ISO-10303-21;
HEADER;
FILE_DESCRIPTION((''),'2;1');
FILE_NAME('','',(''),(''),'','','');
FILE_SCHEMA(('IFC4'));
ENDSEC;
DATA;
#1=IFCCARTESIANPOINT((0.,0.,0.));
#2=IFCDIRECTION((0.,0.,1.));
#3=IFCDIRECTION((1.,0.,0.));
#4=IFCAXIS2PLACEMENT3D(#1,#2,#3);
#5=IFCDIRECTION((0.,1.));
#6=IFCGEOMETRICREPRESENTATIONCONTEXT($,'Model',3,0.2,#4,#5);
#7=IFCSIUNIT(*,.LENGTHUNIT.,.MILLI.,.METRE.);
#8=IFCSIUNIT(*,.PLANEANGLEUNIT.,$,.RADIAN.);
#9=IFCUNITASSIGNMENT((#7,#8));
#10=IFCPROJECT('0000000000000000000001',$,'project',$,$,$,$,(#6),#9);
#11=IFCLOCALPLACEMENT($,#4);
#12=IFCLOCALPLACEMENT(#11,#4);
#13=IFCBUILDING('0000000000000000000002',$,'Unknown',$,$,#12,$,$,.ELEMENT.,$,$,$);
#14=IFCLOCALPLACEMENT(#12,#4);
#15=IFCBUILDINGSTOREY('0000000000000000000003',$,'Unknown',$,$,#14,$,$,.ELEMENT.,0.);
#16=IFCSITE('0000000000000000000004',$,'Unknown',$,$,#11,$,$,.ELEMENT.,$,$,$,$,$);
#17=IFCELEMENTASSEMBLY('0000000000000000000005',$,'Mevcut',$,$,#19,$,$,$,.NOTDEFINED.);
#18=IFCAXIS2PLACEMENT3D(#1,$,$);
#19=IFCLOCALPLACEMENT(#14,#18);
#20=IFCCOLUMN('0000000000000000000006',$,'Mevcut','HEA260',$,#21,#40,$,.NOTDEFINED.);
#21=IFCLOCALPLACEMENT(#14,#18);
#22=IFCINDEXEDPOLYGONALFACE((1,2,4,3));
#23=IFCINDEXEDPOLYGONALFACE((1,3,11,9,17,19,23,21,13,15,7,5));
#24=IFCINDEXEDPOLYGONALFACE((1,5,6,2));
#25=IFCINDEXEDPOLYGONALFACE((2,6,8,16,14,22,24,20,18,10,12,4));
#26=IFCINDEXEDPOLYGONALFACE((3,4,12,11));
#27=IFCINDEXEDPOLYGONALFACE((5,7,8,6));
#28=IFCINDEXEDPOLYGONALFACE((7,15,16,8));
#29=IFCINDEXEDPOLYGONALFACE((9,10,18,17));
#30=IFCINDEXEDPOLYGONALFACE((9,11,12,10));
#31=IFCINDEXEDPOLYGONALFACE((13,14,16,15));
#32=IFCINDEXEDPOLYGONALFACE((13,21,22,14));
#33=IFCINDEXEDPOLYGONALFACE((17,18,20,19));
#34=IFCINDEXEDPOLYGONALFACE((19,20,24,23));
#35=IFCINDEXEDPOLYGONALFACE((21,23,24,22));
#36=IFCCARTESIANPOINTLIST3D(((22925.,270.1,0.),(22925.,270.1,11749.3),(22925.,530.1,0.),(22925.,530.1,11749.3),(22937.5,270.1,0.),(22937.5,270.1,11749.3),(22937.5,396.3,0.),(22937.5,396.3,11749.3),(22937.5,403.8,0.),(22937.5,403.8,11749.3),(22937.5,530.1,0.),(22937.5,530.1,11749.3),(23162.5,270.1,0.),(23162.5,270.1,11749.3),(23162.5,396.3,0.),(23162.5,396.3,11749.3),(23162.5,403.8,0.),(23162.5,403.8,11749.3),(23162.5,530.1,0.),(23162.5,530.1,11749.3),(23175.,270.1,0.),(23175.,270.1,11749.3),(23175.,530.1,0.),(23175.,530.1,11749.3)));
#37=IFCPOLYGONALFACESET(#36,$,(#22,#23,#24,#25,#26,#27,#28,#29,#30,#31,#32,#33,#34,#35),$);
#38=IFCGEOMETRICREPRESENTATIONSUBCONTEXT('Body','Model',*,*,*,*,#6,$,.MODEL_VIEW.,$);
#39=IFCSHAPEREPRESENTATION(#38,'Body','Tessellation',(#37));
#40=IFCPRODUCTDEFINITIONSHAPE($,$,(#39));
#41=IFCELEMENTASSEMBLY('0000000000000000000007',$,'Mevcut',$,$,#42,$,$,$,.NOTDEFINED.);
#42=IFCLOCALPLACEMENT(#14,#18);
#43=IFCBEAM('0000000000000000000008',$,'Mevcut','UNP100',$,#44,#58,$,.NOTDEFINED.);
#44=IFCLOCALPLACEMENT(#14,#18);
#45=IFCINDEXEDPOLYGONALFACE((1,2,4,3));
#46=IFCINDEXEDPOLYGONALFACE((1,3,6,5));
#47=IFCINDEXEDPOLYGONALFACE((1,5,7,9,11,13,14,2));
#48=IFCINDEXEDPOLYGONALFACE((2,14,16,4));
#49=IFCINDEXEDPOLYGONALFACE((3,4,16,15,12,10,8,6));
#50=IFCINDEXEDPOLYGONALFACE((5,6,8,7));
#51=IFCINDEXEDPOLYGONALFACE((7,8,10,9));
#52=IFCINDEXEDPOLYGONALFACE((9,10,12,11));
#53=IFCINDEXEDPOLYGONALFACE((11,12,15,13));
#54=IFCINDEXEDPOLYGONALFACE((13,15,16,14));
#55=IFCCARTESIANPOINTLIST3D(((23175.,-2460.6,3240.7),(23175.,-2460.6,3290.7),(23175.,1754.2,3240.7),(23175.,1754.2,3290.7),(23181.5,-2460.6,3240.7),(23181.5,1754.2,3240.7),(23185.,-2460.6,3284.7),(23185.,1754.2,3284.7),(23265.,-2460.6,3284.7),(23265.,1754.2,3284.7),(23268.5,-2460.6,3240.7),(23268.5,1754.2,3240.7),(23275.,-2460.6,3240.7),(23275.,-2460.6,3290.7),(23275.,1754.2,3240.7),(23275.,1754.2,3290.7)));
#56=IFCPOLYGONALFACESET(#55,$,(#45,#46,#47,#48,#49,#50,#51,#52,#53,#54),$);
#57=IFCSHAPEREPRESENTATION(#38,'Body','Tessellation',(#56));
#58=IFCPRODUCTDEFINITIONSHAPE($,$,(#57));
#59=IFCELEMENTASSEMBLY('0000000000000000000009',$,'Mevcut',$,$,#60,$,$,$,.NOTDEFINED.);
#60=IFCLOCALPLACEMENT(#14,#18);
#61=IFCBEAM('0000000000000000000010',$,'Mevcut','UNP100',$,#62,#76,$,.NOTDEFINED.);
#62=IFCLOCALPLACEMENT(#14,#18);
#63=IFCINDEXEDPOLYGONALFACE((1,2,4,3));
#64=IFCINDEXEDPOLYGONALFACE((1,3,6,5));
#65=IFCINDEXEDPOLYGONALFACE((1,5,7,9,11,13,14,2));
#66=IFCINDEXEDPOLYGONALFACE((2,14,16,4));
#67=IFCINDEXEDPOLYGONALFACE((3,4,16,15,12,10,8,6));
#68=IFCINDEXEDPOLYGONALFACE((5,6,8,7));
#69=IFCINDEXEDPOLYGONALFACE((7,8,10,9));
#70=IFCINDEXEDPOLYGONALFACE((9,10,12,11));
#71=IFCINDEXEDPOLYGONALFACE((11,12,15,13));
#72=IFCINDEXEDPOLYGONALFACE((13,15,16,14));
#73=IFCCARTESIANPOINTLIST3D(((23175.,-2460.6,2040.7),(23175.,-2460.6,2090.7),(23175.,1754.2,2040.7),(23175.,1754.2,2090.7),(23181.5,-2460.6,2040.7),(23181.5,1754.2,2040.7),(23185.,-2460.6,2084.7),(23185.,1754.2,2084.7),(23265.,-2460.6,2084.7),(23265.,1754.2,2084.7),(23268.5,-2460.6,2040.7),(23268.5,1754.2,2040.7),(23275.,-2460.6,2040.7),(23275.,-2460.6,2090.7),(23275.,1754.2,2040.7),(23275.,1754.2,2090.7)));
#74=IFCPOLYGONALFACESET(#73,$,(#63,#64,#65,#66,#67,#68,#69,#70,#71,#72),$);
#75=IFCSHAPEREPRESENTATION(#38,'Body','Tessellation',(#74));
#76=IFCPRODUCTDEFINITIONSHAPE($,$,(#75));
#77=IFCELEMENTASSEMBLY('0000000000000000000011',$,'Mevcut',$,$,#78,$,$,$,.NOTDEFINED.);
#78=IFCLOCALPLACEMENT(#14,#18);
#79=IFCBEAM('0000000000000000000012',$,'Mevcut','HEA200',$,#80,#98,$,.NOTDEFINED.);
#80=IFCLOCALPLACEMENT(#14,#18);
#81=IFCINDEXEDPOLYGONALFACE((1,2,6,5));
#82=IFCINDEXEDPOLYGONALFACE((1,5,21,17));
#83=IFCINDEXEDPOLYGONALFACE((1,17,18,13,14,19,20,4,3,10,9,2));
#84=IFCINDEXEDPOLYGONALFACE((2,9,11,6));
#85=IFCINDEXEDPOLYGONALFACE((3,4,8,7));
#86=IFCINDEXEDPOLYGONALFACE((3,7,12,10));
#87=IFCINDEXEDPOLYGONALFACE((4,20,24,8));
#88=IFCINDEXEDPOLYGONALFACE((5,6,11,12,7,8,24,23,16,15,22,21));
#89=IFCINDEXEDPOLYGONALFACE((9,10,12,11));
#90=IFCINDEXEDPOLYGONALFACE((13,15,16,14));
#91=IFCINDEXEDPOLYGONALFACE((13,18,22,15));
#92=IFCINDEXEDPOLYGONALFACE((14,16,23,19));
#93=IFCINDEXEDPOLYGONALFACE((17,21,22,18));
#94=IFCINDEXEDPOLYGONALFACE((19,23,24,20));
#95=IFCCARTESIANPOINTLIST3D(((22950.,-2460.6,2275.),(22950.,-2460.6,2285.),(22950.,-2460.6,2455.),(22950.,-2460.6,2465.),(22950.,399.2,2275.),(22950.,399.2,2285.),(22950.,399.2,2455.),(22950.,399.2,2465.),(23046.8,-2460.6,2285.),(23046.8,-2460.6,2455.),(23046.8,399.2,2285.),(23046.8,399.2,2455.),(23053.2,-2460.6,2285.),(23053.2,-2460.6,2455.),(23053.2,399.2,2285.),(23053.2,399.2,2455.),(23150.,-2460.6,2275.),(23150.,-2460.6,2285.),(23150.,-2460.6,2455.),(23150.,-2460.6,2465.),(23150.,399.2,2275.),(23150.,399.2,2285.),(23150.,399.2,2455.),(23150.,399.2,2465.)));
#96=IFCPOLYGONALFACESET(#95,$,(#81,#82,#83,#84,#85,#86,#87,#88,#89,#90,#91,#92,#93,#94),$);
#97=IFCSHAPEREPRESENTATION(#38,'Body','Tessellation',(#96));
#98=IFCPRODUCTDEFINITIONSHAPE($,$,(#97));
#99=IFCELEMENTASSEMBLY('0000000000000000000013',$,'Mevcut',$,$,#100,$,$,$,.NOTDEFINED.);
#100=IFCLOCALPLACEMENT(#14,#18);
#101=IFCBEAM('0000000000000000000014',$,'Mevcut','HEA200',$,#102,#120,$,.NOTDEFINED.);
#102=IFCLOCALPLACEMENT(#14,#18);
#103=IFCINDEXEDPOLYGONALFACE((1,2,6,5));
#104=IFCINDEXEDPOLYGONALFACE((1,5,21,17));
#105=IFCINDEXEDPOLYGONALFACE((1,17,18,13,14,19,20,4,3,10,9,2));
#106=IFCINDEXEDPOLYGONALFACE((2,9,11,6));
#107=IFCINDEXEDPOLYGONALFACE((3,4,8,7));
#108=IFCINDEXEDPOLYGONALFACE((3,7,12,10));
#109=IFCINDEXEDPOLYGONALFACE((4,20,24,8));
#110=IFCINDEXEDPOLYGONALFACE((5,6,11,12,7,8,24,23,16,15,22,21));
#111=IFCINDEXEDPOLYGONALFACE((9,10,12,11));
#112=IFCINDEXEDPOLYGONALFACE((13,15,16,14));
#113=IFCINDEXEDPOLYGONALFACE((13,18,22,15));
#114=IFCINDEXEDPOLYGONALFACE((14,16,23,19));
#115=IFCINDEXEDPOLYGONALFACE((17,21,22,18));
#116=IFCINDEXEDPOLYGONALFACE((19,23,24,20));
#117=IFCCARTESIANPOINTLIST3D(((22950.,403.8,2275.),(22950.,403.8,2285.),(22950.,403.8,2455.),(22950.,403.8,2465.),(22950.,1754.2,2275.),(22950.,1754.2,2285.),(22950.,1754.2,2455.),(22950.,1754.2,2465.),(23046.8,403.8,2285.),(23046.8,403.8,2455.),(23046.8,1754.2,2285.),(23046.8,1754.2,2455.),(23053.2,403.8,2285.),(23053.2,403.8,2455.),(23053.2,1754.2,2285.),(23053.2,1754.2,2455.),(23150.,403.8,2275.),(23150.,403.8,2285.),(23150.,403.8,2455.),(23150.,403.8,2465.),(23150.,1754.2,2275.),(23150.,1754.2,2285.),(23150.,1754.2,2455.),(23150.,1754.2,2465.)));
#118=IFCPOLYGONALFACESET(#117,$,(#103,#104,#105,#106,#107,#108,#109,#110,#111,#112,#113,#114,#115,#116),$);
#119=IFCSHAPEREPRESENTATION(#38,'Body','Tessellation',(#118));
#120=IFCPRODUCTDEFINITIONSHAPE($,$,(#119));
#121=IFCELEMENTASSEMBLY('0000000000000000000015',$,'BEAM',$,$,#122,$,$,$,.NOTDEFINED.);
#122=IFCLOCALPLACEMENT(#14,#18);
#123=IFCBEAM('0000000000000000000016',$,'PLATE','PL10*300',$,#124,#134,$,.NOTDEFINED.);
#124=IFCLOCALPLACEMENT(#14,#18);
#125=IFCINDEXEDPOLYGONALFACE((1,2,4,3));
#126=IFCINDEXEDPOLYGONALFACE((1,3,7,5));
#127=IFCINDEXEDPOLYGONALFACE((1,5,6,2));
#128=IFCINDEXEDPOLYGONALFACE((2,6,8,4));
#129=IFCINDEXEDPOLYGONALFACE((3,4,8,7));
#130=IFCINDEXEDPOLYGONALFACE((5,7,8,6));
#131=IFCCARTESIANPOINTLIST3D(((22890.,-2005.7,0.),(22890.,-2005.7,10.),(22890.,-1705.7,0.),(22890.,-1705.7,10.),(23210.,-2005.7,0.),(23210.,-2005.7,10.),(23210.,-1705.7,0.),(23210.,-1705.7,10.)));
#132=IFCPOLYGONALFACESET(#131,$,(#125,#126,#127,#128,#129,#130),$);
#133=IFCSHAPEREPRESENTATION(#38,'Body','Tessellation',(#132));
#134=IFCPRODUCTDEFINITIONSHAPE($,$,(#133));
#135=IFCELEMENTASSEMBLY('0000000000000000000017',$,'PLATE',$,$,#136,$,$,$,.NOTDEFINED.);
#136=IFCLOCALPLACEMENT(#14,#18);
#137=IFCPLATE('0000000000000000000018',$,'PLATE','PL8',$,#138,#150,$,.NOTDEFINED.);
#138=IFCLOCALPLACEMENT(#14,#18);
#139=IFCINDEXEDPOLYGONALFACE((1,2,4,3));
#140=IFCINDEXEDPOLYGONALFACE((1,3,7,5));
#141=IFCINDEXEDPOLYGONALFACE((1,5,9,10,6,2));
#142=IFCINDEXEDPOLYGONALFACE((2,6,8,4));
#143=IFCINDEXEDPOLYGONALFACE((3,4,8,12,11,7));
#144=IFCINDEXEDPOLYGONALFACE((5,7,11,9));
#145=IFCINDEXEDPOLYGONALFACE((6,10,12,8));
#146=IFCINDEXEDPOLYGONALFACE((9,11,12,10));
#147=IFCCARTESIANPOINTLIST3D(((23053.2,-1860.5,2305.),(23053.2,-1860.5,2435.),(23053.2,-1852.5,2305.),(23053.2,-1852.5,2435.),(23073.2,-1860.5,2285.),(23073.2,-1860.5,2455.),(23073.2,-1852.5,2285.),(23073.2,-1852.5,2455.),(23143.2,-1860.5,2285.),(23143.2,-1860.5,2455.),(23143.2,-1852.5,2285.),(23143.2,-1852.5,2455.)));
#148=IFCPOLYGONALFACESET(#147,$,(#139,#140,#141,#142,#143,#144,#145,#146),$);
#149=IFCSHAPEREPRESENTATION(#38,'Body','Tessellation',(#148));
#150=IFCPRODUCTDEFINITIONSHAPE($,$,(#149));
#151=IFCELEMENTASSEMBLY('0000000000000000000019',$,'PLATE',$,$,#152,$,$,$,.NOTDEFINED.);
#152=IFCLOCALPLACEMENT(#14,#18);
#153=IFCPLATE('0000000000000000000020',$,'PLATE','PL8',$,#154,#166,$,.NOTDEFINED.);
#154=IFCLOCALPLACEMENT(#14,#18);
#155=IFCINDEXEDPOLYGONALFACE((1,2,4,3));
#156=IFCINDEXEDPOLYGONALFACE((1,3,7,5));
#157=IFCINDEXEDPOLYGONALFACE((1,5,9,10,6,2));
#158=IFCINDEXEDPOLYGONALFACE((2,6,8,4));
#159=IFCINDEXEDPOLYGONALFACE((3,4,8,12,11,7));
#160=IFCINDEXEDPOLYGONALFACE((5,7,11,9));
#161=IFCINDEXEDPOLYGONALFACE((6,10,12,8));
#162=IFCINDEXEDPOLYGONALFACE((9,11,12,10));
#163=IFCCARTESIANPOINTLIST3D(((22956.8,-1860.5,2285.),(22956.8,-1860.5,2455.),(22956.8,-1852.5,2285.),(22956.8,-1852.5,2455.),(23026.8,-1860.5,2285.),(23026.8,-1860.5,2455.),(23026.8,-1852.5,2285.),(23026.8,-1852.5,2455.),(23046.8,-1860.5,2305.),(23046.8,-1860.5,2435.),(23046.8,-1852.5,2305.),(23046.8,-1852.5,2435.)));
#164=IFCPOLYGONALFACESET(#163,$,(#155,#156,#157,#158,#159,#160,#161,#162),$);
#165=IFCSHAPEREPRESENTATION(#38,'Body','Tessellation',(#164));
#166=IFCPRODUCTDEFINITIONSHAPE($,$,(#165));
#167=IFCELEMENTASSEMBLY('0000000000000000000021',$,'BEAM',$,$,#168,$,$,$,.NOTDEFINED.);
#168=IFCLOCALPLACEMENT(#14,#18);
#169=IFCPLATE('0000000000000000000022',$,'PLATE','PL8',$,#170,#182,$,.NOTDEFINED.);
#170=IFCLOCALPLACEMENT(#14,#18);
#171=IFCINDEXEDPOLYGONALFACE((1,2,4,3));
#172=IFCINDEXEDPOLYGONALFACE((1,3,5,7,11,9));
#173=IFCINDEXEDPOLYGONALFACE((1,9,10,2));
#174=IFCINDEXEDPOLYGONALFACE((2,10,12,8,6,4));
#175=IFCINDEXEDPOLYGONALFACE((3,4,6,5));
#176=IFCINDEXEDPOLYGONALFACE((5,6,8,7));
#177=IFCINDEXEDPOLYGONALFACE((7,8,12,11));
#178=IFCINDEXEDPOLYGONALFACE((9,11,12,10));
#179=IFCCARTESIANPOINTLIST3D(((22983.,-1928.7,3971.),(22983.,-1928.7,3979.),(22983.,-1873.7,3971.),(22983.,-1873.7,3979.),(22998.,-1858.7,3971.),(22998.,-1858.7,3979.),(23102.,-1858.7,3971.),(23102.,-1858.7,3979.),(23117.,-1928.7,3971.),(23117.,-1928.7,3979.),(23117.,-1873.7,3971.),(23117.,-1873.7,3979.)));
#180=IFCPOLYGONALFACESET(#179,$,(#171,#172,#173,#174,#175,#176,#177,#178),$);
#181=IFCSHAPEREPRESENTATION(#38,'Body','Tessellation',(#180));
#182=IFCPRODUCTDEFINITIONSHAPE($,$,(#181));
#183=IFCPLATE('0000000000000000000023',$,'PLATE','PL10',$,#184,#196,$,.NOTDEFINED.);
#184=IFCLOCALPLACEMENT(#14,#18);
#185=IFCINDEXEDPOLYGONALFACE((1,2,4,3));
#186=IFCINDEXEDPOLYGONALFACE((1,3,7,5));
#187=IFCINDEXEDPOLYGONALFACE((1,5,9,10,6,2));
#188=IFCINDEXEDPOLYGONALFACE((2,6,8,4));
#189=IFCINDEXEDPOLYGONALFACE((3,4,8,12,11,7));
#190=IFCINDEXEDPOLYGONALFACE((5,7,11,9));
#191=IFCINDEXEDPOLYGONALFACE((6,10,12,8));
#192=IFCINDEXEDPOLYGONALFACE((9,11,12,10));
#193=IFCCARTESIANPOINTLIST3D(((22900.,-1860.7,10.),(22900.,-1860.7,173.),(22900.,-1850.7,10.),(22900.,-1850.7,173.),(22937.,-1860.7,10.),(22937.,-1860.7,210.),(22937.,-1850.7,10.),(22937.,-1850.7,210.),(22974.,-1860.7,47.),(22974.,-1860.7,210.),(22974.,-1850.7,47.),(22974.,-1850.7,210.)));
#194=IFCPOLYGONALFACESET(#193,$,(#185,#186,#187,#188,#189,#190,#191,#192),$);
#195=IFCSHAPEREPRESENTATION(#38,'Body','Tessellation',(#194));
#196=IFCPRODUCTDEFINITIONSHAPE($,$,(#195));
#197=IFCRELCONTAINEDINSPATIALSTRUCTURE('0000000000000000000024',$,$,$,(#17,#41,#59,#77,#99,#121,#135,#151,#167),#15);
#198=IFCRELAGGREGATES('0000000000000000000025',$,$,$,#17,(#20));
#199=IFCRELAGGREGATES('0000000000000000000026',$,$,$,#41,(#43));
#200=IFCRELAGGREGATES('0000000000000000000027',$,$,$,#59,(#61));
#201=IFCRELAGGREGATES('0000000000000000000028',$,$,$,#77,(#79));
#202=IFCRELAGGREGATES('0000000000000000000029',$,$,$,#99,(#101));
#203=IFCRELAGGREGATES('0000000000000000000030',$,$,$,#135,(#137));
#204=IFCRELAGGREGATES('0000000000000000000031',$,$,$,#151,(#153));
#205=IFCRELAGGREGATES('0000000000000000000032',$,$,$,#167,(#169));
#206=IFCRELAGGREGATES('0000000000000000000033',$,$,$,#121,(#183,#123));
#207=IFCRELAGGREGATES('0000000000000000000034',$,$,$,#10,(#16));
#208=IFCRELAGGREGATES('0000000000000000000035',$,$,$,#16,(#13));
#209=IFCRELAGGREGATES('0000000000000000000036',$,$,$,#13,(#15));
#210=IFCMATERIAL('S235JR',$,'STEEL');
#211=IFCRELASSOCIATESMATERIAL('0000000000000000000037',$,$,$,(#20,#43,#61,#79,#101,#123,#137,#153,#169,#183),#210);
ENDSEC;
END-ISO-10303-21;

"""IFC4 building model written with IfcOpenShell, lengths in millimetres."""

from ifc_helpers import new_model, si_unit, direction, frame, origin_with_axes, place, context, subcontext, project, spatial, line, indexed_curve, outline, extrude, material, element, aggregate, save


model = new_model("IFC4")

# Units and contexts
model_context = context("Model", 3, precision=0.2, world=origin_with_axes(), true_north=direction((0.0, 1.0)))
body_context = subcontext(model_context, "Body", "Model", "MODEL_VIEW")
ifc_project = project(units=[si_unit("LENGTHUNIT", "METRE", prefix="MILLI"), si_unit("PLANEANGLEUNIT", "RADIAN")], contexts=[model_context])

# Site, building, storey
site_placement = place(None, origin_with_axes())
site = spatial("IfcSite", under=ifc_project, at=site_placement, Name="Unknown", CompositionType="ELEMENT")
building_placement = place(site_placement, origin_with_axes())
building = spatial("IfcBuilding", under=site, at=building_placement, Name="Unknown", CompositionType="ELEMENT")
storey_placement = place(building_placement, origin_with_axes())
storey = spatial("IfcBuildingStorey", under=building, at=storey_placement, Name="Unknown", CompositionType="ELEMENT", Elevation=0.0)

# Element assembly, column
assembly_1_placement = place(storey_placement, frame((23050.0, 400.1, 0.0), z_axis=(0.0, -1.0, 0.0), x_axis=(0.0, 0.0, 1.0)))
assembly_1 = element("IfcElementAssembly", 1, at=assembly_1_placement, inside=storey, Name="Mevcut", PredefinedType="NOTDEFINED")
ifc_material_1 = material(Name="S235JR", Category="STEEL")
column_placement = place(assembly_1_placement, origin_with_axes())
column = element("IfcColumn", 2, at=column_placement, material=ifc_material_1, Name="Mevcut", Description="HEA260", PredefinedType="NOTDEFINED", context=body_context, shape_type="SolidModel", body=[
    extrude(outline(indexed_curve([(-130.0, -125.0), (130.0, -125.0), (130.0, -112.5), (3.8, -112.5), (3.8, 112.5), (130.0, 112.5), (130.0, 125.0), (-130.0, 125.0), (-130.0, 112.5), (-3.8, 112.5), (-3.8, -112.5), (-130.0, -112.5)], segments=[line(1, 2, 3, 4, 5, 6, 7, 8, 9, 10, 11, 12, 1)])), frame((0.0, 0.0, 0.0), z_axis=(-1.0, 0.0, 0.0), x_axis=(0.0, 0.0, 1.0)), (0.0, 0.0, -1.0), 11749.3),
])
aggregate(assembly_1, [column])

# Element assemblies, beams
assembly_2_placement = place(storey_placement, frame((23225.0, 1754.2, 3265.7), z_axis=(0.0, 0.0, -1.0), x_axis=(0.0, -1.0, 0.0)))
assembly_2 = element("IfcElementAssembly", 3, at=assembly_2_placement, inside=storey, Name="Mevcut", PredefinedType="NOTDEFINED")
beam_1_placement = place(assembly_2_placement, origin_with_axes())
beam_1 = element("IfcBeam", 4, at=beam_1_placement, material=ifc_material_1, Name="Mevcut", Description="UNP100", PredefinedType="NOTDEFINED", context=body_context, shape_type="SolidModel", body=[
    extrude(outline(indexed_curve([(-25.0, -50.0), (25.0, -50.0), (25.0, -43.5), (-19.0, -40.0), (-19.0, 40.0), (25.0, 43.5), (25.0, 50.0), (-25.0, 50.0)], segments=[line(1, 2, 3, 4, 5, 6, 7, 8, 1)])), frame((0.0, 0.0, 0.0), z_axis=(-1.0, 0.0, 0.0), x_axis=(0.0, 0.0, 1.0)), (0.0, 0.0, -1.0), 4214.9),
])
aggregate(assembly_2, [beam_1])
assembly_3_placement = place(storey_placement, frame((23225.0, 1754.2, 2065.7), z_axis=(0.0, 0.0, -1.0), x_axis=(0.0, -1.0, 0.0)))
assembly_3 = element("IfcElementAssembly", 5, at=assembly_3_placement, inside=storey, Name="Mevcut", PredefinedType="NOTDEFINED")
beam_2_placement = place(assembly_3_placement, origin_with_axes())
beam_2 = element("IfcBeam", 6, at=beam_2_placement, material=ifc_material_1, Name="Mevcut", Description="UNP100", PredefinedType="NOTDEFINED", context=body_context, shape_type="SolidModel", body=[
    extrude(outline(indexed_curve([(-25.0, -50.0), (25.0, -50.0), (25.0, -43.5), (-19.0, -40.0), (-19.0, 40.0), (25.0, 43.5), (25.0, 50.0), (-25.0, 50.0)], segments=[line(1, 2, 3, 4, 5, 6, 7, 8, 1)])), frame((0.0, 0.0, 0.0), z_axis=(-1.0, 0.0, 0.0), x_axis=(0.0, 0.0, 1.0)), (0.0, 0.0, -1.0), 4214.9),
])
aggregate(assembly_3, [beam_2])
assembly_4_placement = place(storey_placement, frame((23050.0, 399.2, 2370.0), z_axis=(-1.0, 0.0, 0.0), x_axis=(0.0, -1.0, 0.0)))
assembly_4 = element("IfcElementAssembly", 7, at=assembly_4_placement, inside=storey, Name="Mevcut", PredefinedType="NOTDEFINED")
beam_3_placement = place(assembly_4_placement, origin_with_axes())
beam_3 = element("IfcBeam", 8, at=beam_3_placement, material=ifc_material_1, Name="Mevcut", Description="HEA200", PredefinedType="NOTDEFINED", context=body_context, shape_type="SolidModel", body=[
    extrude(outline(indexed_curve([(-100.0, -95.0), (100.0, -95.0), (100.0, -85.0), (3.2, -85.0), (3.2, 85.0), (100.0, 85.0), (100.0, 95.0), (-100.0, 95.0), (-100.0, 85.0), (-3.2, 85.0), (-3.2, -85.0), (-100.0, -85.0)], segments=[line(1, 2, 3, 4, 5, 6, 7, 8, 9, 10, 11, 12, 1)])), frame((0.0, 0.0, 0.0), z_axis=(-1.0, 0.0, 0.0), x_axis=(0.0, 0.0, 1.0)), (0.0, 0.0, -1.0), 2859.9),
])
aggregate(assembly_4, [beam_3])
assembly_5_placement = place(storey_placement, frame((23050.0, 1754.2, 2370.0), z_axis=(-1.0, 0.0, 0.0), x_axis=(0.0, -1.0, 0.0)))
assembly_5 = element("IfcElementAssembly", 9, at=assembly_5_placement, inside=storey, Name="Mevcut", PredefinedType="NOTDEFINED")
beam_4_placement = place(assembly_5_placement, origin_with_axes())
beam_4 = element("IfcBeam", 10, at=beam_4_placement, material=ifc_material_1, Name="Mevcut", Description="HEA200", PredefinedType="NOTDEFINED", context=body_context, shape_type="SolidModel", body=[
    extrude(outline(indexed_curve([(-100.0, -95.0), (100.0, -95.0), (100.0, -85.0), (3.2, -85.0), (3.2, 85.0), (100.0, 85.0), (100.0, 95.0), (-100.0, 95.0), (-100.0, 85.0), (-3.2, 85.0), (-3.2, -85.0), (-100.0, -85.0)], segments=[line(1, 2, 3, 4, 5, 6, 7, 8, 9, 10, 11, 12, 1)])), frame((0.0, 0.0, 0.0), z_axis=(-1.0, 0.0, 0.0), x_axis=(0.0, 0.0, 1.0)), (0.0, 0.0, -1.0), 1350.4),
])
aggregate(assembly_5, [beam_4])
assembly_6_placement = place(storey_placement, frame((23050.0, -1855.7, 2275.0), z_axis=(0.0, -1.0, 0.0), x_axis=(0.0, 0.0, -1.0)))
assembly_6 = element("IfcElementAssembly", 11, at=assembly_6_placement, inside=storey, Name="BEAM", PredefinedType="NOTDEFINED")
beam_5_placement = place(assembly_6_placement, frame((2270.0, -160.0, 0.0), z_axis=(-1.0, 0.0, 0.0), x_axis=(0.0, 1.0, 0.0)))
beam_5 = element("IfcBeam", 12, at=beam_5_placement, material=ifc_material_1, Name="PLATE", Description="PL10*300", PredefinedType="NOTDEFINED", context=body_context, shape_type="SolidModel", body=[
    extrude(outline(indexed_curve([(-5.0, -150.0), (5.0, -150.0), (5.0, 150.0), (-5.0, 150.0)], segments=[line(1, 2, 3, 4, 1)])), frame((0.0, 0.0, 0.0), z_axis=(-1.0, 0.0, 0.0), x_axis=(0.0, 0.0, 1.0)), (0.0, 0.0, -1.0), 320.0),
])

# Element assemblies, plates
assembly_7_placement = place(storey_placement, frame((23053.2, -1856.5, 2285.0), z_axis=(0.0, -1.0, 0.0), x_axis=(1.0, 0.0, 0.0)))
assembly_7 = element("IfcElementAssembly", 13, at=assembly_7_placement, inside=storey, Name="PLATE", PredefinedType="NOTDEFINED")
plate_1_placement = place(assembly_7_placement, origin_with_axes())
plate_1 = element("IfcPlate", 14, at=plate_1_placement, material=ifc_material_1, Name="PLATE", Description="PL8", PredefinedType="NOTDEFINED", context=body_context, shape_type="SolidModel", body=[
    extrude(outline(indexed_curve([(0.0, 20.0), (20.0, 0.0), (90.0, 0.0), (90.0, 170.0), (20.0, 170.0), (0.0, 150.0)], segments=[line(1, 2, 3, 4, 5, 6, 1)])), frame((0.0, 0.0, 4.0), z_axis=(0.0, 0.0, 1.0), x_axis=(1.0, 0.0, 0.0)), (0.0, 0.0, -1.0), 8.0),
])
aggregate(assembly_7, [plate_1])
assembly_8_placement = place(storey_placement, frame((23046.8, -1856.5, 2285.0), z_axis=(0.0, 1.0, 0.0), x_axis=(-1.0, 0.0, 0.0)))
assembly_8 = element("IfcElementAssembly", 15, at=assembly_8_placement, inside=storey, Name="PLATE", PredefinedType="NOTDEFINED")
plate_2_placement = place(assembly_8_placement, origin_with_axes())
plate_2 = element("IfcPlate", 16, at=plate_2_placement, material=ifc_material_1, Name="PLATE", Description="PL8", PredefinedType="NOTDEFINED", context=body_context, shape_type="SolidModel", body=[
    extrude(outline(indexed_curve([(0.0, 20.0), (20.0, 0.0), (90.0, 0.0), (90.0, 170.0), (20.0, 170.0), (0.0, 150.0)], segments=[line(1, 2, 3, 4, 5, 6, 1)])), frame((0.0, 0.0, 4.0), z_axis=(0.0, 0.0, 1.0), x_axis=(1.0, 0.0, 0.0)), (0.0, 0.0, -1.0), 8.0),
])
aggregate(assembly_8, [plate_2])

# Element assembly, plate
assembly_9_placement = place(storey_placement, frame((23050.0, -1855.7, 4975.0), z_axis=(0.0, -1.0, 0.0), x_axis=(0.0, 0.0, -1.0)))
assembly_9 = element("IfcElementAssembly", 17, at=assembly_9_placement, inside=storey, Name="BEAM", PredefinedType="NOTDEFINED")
plate_3_placement = place(assembly_9_placement, frame((1000.0, -67.0, 3.0), z_axis=(-1.0, 0.0, 0.0), x_axis=(0.0, 0.0, 1.0)))
plate_3 = element("IfcPlate", 18, at=plate_3_placement, material=ifc_material_1, Name="PLATE", Description="PL8", PredefinedType="NOTDEFINED", context=body_context, shape_type="SolidModel", body=[
    extrude(outline(indexed_curve([(0.0, 15.0), (15.0, 0.0), (70.0, 0.0), (70.0, 134.0), (15.0, 134.0), (0.0, 119.0)], segments=[line(1, 2, 3, 4, 5, 6, 1)])), frame((0.0, 0.0, 4.0), z_axis=(0.0, 0.0, 1.0), x_axis=(1.0, 0.0, 0.0)), (0.0, 0.0, -1.0), 8.0),
])
aggregate(assembly_9, [plate_3])

# Plate
plate_4_placement = place(assembly_6_placement, frame((2228.0, -76.0, 0.0), z_axis=(0.0, 0.0, -1.0), x_axis=(0.707107, -0.707107, 0.0)))
plate_4 = element("IfcPlate", 19, at=plate_4_placement, material=ifc_material_1, Name="PLATE", Description="PL10", PredefinedType="NOTDEFINED", context=body_context, shape_type="SolidModel", body=[
    extrude(outline(indexed_curve([(0.0, 0.0), (52.3, 0.0), (78.5, 26.2), (-36.8, 141.4), (-89.1, 141.4), (-115.3, 115.3)], segments=[line(1, 2, 3, 4, 5, 6, 1)])), frame((0.0, 0.0, 5.0), z_axis=(0.0, 0.0, 1.0), x_axis=(1.0, 0.0, 0.0)), (0.0, 0.0, -1.0), 10.0),
])

aggregate(assembly_6, [plate_4, beam_5])

save(model, "model.ifc")
